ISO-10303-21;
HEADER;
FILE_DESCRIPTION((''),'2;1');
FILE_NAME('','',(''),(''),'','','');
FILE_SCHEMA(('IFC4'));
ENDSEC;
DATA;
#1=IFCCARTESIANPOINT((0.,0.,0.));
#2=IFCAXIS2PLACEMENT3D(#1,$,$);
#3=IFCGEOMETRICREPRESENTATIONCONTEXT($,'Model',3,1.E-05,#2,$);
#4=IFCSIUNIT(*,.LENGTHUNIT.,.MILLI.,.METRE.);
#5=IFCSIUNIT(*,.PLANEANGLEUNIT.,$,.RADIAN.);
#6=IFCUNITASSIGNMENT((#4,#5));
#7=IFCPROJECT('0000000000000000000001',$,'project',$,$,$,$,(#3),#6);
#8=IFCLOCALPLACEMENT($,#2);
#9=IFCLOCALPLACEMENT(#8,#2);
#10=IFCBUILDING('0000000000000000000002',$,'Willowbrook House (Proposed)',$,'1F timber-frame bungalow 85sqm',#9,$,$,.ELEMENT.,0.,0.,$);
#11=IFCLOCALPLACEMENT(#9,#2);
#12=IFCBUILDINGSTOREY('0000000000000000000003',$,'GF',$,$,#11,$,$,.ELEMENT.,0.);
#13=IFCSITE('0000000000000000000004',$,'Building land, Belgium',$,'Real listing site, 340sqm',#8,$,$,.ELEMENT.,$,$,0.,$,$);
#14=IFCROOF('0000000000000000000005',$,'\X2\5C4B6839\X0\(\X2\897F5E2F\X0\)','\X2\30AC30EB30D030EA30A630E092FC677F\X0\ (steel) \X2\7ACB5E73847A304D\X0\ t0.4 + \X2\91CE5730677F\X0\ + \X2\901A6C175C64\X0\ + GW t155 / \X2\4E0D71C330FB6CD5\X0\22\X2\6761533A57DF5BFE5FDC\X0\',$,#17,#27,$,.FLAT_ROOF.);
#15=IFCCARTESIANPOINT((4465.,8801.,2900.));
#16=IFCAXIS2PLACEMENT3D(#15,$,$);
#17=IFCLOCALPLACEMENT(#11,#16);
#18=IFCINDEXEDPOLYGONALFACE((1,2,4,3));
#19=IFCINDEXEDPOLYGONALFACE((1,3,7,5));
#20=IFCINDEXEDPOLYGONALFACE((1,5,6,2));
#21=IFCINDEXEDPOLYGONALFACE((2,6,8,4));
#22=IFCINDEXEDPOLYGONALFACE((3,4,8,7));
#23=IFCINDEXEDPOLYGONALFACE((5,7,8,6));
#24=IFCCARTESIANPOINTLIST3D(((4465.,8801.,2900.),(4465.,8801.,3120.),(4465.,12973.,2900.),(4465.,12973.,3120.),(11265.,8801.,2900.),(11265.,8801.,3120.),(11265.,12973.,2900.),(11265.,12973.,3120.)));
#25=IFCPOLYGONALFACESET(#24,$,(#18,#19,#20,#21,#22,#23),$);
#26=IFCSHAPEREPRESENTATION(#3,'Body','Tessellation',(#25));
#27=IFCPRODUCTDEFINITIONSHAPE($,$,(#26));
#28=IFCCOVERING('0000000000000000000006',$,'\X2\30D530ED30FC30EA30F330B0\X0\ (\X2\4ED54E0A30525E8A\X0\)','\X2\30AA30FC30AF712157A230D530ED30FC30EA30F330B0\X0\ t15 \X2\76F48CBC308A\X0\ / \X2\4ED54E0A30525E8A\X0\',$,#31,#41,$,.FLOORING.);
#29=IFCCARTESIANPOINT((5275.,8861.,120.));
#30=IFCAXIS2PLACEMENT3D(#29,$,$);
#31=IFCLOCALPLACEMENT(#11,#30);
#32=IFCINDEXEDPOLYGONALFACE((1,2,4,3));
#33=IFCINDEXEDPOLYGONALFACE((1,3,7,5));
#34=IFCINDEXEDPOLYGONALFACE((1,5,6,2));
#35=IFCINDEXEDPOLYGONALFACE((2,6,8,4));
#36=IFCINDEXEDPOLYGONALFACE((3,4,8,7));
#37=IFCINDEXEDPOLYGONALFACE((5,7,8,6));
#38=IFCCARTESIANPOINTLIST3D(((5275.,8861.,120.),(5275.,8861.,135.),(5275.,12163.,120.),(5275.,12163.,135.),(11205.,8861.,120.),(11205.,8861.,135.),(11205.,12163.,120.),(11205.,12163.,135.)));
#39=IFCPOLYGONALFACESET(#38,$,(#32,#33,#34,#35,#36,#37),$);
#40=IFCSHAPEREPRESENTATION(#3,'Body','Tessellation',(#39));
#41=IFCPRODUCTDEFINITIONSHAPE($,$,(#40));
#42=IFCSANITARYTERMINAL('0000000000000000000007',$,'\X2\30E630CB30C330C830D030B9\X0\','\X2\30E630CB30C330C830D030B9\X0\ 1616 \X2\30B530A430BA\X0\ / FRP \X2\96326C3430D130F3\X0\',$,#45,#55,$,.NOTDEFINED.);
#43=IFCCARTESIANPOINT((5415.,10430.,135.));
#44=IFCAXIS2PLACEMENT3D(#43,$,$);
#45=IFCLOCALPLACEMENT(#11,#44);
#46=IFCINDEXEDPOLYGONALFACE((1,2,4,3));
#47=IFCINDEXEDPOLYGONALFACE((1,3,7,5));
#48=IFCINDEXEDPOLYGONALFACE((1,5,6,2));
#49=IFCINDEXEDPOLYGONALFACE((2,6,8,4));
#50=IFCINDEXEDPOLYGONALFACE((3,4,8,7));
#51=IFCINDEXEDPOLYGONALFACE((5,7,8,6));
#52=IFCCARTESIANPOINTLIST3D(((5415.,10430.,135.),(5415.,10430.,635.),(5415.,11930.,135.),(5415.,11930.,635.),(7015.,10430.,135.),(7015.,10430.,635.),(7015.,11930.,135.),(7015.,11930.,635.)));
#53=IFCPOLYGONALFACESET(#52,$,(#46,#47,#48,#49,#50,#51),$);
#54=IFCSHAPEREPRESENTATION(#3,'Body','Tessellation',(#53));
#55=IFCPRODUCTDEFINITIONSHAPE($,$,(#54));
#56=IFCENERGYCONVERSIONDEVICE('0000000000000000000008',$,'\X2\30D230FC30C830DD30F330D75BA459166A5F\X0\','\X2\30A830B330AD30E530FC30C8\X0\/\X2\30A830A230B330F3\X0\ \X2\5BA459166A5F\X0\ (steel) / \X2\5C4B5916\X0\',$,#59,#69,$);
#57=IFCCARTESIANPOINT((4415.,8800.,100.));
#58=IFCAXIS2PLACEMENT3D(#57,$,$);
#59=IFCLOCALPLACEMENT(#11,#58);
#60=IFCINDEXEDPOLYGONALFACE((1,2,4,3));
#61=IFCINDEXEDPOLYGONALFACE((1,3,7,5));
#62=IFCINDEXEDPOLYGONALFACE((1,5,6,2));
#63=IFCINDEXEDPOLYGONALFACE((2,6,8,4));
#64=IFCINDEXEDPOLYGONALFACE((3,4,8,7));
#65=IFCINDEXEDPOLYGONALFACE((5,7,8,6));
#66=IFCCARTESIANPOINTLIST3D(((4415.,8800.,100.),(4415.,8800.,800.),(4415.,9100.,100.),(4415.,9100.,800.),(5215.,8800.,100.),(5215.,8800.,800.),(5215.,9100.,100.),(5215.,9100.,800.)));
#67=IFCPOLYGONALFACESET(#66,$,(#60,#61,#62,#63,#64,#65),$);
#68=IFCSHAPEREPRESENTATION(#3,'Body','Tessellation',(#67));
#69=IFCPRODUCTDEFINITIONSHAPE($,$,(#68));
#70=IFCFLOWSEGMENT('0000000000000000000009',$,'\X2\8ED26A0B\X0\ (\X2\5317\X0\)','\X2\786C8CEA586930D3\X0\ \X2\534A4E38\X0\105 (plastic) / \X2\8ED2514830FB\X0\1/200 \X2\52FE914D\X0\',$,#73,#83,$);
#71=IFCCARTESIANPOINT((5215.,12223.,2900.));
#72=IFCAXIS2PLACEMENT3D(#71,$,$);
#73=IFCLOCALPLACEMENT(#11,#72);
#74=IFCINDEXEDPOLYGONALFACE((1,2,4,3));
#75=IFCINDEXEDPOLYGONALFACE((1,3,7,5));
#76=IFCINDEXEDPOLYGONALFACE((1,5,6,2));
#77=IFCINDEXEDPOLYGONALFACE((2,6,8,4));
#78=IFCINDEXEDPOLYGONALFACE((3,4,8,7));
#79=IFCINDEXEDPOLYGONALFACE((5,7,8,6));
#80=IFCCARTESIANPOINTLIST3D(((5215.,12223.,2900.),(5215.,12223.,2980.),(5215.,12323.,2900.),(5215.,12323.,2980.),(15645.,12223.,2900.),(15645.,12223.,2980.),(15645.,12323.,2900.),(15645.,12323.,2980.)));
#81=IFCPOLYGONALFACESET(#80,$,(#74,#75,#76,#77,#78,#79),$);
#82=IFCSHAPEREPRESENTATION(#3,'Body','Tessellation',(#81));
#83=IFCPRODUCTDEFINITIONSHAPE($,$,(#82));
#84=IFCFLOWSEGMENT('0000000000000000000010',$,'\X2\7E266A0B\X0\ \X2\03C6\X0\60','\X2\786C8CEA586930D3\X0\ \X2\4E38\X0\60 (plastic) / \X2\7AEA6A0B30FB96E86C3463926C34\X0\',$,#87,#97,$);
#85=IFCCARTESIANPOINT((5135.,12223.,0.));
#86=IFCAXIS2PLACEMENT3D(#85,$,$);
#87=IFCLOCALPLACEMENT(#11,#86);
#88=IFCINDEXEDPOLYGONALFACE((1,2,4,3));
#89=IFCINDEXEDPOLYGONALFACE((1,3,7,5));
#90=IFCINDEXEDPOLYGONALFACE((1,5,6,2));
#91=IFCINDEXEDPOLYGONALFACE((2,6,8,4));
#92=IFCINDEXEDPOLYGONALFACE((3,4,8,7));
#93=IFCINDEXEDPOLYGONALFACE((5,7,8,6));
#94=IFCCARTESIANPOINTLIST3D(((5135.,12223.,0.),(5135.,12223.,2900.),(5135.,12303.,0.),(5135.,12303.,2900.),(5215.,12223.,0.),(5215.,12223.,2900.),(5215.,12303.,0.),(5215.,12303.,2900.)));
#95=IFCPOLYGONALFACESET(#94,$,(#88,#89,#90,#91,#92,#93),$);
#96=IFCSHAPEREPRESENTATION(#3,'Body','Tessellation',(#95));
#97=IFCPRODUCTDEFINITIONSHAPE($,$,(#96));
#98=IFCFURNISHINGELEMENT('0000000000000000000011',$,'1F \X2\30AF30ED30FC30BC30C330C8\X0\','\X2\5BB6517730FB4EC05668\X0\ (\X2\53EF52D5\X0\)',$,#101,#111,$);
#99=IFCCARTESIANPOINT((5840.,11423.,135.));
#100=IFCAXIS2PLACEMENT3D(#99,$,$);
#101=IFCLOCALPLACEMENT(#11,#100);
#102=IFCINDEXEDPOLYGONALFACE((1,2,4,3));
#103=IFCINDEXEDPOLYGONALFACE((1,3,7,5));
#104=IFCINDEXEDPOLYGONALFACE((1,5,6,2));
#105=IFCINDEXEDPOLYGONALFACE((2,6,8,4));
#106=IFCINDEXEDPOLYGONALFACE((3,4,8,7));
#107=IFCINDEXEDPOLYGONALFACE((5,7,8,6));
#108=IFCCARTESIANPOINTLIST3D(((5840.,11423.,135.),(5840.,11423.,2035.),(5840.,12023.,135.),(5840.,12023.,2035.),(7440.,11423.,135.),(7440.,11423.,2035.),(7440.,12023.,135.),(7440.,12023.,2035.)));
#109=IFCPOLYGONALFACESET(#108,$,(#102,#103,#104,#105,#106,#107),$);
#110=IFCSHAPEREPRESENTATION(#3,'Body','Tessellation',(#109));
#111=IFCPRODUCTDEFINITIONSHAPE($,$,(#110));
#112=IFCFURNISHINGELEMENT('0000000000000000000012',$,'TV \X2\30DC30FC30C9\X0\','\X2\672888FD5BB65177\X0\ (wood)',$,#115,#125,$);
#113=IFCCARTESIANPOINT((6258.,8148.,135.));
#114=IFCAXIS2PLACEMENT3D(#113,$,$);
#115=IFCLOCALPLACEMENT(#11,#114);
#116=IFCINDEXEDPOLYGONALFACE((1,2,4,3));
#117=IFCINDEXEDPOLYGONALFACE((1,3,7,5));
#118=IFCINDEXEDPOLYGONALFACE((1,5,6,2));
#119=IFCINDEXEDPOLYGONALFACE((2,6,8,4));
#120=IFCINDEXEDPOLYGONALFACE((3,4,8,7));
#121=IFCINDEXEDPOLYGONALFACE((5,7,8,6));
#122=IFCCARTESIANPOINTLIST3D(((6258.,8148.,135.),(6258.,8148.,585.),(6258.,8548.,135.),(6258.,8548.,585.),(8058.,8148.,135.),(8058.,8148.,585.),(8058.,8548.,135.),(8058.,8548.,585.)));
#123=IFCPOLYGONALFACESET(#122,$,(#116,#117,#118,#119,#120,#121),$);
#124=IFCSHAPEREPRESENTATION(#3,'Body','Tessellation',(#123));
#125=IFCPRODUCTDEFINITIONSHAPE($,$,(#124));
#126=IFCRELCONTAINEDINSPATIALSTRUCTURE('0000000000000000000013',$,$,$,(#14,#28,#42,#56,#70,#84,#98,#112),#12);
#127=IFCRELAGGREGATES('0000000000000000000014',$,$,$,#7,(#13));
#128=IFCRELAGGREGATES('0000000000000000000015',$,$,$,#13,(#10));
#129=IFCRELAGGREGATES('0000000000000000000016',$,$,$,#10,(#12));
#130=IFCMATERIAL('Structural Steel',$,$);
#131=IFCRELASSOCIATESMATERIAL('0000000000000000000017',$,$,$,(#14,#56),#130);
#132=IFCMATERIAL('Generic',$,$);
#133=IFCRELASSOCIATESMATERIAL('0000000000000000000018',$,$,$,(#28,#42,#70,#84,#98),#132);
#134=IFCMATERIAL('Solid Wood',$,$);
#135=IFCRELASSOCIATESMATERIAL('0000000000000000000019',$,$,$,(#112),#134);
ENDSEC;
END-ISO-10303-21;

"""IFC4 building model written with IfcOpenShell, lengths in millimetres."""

from ifc_helpers import new_model, si_unit, frame, frame_2d, origin, place, context, project, spatial, rectangle, extrude, material, element, save


model = new_model("IFC4")

# Units and contexts
model_context = context("Model", 3, precision=1e-05, world=origin())
ifc_project = project(units=[si_unit("LENGTHUNIT", "METRE", prefix="MILLI"), si_unit("PLANEANGLEUNIT", "RADIAN")], contexts=[model_context])

# Site, building, storey
site_placement = place(None, origin())
site = spatial("IfcSite", under=ifc_project, at=site_placement, Name="Building land, Belgium", ObjectType="Real listing site, 340sqm", CompositionType="ELEMENT", RefElevation=0.0)
building_placement = place(site_placement, origin())
building = spatial("IfcBuilding", under=site, at=building_placement, Name="Willowbrook House (Proposed)", ObjectType="1F timber-frame bungalow 85sqm", CompositionType="ELEMENT", ElevationOfRefHeight=0.0, ElevationOfTerrain=0.0)
storey_placement = place(building_placement, origin())
storey = spatial("IfcBuildingStorey", under=building, at=storey_placement, Name="GF", CompositionType="ELEMENT", Elevation=0.0)

# Shared definitions
ifc_material_1 = material(Name="Solid Wood")

# Roof
ifc_material_2 = material(Name="Structural Steel")
roof_placement = place(storey_placement, frame((4465.0, 8801.0, 2900.0)))
element("IfcRoof", 1, at=roof_placement, inside=storey, material=ifc_material_2, Name="屋根(西帯)", Description="ガルバリウム鋼板 (steel) 立平葺き t0.4 + 野地板 + 通気層 + GW t155 / 不燃・法22条区域対応", PredefinedType="FLAT_ROOF", context=model_context, shape_type="SweptSolid", body=[
    extrude(rectangle(XDim=6800.0, YDim=4172.0, at=frame_2d((3400.0, 2086.0))), frame((4465.0, 8801.0, 2900.0)), (0.0, 0.0, 1.0), 220.0),
])

# Covering
ifc_material_3 = material(Name="Generic")
covering_placement = place(storey_placement, frame((5275.0, 8861.0, 120.0)))
element("IfcCovering", 2, at=covering_placement, inside=storey, material=ifc_material_3, Name="フローリング (仕上げ床)", Description="オーク無垢フローリング t15 直貼り / 仕上げ床", PredefinedType="FLOORING", context=model_context, shape_type="SweptSolid", body=[
    extrude(rectangle(XDim=5930.0, YDim=3302.0, at=frame_2d((2965.0, 1651.0))), frame((5275.0, 8861.0, 120.0)), (0.0, 0.0, 1.0), 15.0),
])

# Sanitary terminal
sanitary_terminal_placement = place(storey_placement, frame((5415.0, 10430.0, 135.0)))
element("IfcSanitaryTerminal", 3, at=sanitary_terminal_placement, inside=storey, material=ifc_material_3, Name="ユニットバス", Description="ユニットバス 1616 サイズ / FRP 防水パン", PredefinedType="NOTDEFINED", context=model_context, shape_type="SweptSolid", body=[
    extrude(rectangle(XDim=1600.0, YDim=1500.0, at=frame_2d((800.0, 750.0))), frame((5415.0, 10430.0, 135.0)), (0.0, 0.0, 1.0), 500.0),
])

# Energy conversion device
energy_conversion_device_placement = place(storey_placement, frame((4415.0, 8800.0, 100.0)))
element("IfcEnergyConversionDevice", 4, at=energy_conversion_device_placement, inside=storey, material=ifc_material_2, Name="ヒートポンプ室外機", Description="エコキュート/エアコン 室外機 (steel) / 屋外", context=model_context, shape_type="SweptSolid", body=[
    extrude(rectangle(XDim=800.0, YDim=300.0, at=frame_2d((400.0, 150.0))), frame((4415.0, 8800.0, 100.0)), (0.0, 0.0, 1.0), 700.0),
])

# Flow segments
flow_segment_1_placement = place(storey_placement, frame((5215.0, 12223.0, 2900.0)))
element("IfcFlowSegment", 5, at=flow_segment_1_placement, inside=storey, material=ifc_material_3, Name="軒樋 (北)", Description="硬質塩ビ 半丸105 (plastic) / 軒先・1/200 勾配", context=model_context, shape_type="SweptSolid", body=[
    extrude(rectangle(XDim=10430.0, YDim=100.0, at=frame_2d((5215.0, 50.0))), frame((5215.0, 12223.0, 2900.0)), (0.0, 0.0, 1.0), 80.0),
])
flow_segment_2_placement = place(storey_placement, frame((5135.0, 12223.0, 0.0)))
element("IfcFlowSegment", 6, at=flow_segment_2_placement, inside=storey, material=ifc_material_3, Name="縦樋 φ60", Description="硬質塩ビ 丸60 (plastic) / 竪樋・雨水排水", context=model_context, shape_type="SweptSolid", body=[
    extrude(rectangle(XDim=80.0, YDim=80.0, at=frame_2d((40.0, 40.0))), frame((5135.0, 12223.0, 0.0)), (0.0, 0.0, 1.0), 2900.0),
])

# Furnishing elements
furnishing_1_placement = place(storey_placement, frame((5840.0, 11423.0, 135.0)))
element("IfcFurnishingElement", 7, at=furnishing_1_placement, inside=storey, material=ifc_material_3, Name="1F クローゼット", Description="家具・什器 (可動)", context=model_context, shape_type="SweptSolid", body=[
    extrude(rectangle(XDim=1600.0, YDim=600.0, at=frame_2d((800.0, 300.0))), frame((5840.0, 11423.0, 135.0)), (0.0, 0.0, 1.0), 1900.0),
])
furnishing_2_placement = place(storey_placement, frame((6258.0, 8148.0, 135.0)))
element("IfcFurnishingElement", 8, at=furnishing_2_placement, inside=storey, material=ifc_material_1, Name="TV ボード", Description="木製家具 (wood)", context=model_context, shape_type="SweptSolid", body=[
    extrude(rectangle(XDim=1800.0, YDim=400.0, at=frame_2d((900.0, 200.0))), frame((6258.0, 8148.0, 135.0)), (0.0, 0.0, 1.0), 450.0),
])

save(model, "model.ifc")
